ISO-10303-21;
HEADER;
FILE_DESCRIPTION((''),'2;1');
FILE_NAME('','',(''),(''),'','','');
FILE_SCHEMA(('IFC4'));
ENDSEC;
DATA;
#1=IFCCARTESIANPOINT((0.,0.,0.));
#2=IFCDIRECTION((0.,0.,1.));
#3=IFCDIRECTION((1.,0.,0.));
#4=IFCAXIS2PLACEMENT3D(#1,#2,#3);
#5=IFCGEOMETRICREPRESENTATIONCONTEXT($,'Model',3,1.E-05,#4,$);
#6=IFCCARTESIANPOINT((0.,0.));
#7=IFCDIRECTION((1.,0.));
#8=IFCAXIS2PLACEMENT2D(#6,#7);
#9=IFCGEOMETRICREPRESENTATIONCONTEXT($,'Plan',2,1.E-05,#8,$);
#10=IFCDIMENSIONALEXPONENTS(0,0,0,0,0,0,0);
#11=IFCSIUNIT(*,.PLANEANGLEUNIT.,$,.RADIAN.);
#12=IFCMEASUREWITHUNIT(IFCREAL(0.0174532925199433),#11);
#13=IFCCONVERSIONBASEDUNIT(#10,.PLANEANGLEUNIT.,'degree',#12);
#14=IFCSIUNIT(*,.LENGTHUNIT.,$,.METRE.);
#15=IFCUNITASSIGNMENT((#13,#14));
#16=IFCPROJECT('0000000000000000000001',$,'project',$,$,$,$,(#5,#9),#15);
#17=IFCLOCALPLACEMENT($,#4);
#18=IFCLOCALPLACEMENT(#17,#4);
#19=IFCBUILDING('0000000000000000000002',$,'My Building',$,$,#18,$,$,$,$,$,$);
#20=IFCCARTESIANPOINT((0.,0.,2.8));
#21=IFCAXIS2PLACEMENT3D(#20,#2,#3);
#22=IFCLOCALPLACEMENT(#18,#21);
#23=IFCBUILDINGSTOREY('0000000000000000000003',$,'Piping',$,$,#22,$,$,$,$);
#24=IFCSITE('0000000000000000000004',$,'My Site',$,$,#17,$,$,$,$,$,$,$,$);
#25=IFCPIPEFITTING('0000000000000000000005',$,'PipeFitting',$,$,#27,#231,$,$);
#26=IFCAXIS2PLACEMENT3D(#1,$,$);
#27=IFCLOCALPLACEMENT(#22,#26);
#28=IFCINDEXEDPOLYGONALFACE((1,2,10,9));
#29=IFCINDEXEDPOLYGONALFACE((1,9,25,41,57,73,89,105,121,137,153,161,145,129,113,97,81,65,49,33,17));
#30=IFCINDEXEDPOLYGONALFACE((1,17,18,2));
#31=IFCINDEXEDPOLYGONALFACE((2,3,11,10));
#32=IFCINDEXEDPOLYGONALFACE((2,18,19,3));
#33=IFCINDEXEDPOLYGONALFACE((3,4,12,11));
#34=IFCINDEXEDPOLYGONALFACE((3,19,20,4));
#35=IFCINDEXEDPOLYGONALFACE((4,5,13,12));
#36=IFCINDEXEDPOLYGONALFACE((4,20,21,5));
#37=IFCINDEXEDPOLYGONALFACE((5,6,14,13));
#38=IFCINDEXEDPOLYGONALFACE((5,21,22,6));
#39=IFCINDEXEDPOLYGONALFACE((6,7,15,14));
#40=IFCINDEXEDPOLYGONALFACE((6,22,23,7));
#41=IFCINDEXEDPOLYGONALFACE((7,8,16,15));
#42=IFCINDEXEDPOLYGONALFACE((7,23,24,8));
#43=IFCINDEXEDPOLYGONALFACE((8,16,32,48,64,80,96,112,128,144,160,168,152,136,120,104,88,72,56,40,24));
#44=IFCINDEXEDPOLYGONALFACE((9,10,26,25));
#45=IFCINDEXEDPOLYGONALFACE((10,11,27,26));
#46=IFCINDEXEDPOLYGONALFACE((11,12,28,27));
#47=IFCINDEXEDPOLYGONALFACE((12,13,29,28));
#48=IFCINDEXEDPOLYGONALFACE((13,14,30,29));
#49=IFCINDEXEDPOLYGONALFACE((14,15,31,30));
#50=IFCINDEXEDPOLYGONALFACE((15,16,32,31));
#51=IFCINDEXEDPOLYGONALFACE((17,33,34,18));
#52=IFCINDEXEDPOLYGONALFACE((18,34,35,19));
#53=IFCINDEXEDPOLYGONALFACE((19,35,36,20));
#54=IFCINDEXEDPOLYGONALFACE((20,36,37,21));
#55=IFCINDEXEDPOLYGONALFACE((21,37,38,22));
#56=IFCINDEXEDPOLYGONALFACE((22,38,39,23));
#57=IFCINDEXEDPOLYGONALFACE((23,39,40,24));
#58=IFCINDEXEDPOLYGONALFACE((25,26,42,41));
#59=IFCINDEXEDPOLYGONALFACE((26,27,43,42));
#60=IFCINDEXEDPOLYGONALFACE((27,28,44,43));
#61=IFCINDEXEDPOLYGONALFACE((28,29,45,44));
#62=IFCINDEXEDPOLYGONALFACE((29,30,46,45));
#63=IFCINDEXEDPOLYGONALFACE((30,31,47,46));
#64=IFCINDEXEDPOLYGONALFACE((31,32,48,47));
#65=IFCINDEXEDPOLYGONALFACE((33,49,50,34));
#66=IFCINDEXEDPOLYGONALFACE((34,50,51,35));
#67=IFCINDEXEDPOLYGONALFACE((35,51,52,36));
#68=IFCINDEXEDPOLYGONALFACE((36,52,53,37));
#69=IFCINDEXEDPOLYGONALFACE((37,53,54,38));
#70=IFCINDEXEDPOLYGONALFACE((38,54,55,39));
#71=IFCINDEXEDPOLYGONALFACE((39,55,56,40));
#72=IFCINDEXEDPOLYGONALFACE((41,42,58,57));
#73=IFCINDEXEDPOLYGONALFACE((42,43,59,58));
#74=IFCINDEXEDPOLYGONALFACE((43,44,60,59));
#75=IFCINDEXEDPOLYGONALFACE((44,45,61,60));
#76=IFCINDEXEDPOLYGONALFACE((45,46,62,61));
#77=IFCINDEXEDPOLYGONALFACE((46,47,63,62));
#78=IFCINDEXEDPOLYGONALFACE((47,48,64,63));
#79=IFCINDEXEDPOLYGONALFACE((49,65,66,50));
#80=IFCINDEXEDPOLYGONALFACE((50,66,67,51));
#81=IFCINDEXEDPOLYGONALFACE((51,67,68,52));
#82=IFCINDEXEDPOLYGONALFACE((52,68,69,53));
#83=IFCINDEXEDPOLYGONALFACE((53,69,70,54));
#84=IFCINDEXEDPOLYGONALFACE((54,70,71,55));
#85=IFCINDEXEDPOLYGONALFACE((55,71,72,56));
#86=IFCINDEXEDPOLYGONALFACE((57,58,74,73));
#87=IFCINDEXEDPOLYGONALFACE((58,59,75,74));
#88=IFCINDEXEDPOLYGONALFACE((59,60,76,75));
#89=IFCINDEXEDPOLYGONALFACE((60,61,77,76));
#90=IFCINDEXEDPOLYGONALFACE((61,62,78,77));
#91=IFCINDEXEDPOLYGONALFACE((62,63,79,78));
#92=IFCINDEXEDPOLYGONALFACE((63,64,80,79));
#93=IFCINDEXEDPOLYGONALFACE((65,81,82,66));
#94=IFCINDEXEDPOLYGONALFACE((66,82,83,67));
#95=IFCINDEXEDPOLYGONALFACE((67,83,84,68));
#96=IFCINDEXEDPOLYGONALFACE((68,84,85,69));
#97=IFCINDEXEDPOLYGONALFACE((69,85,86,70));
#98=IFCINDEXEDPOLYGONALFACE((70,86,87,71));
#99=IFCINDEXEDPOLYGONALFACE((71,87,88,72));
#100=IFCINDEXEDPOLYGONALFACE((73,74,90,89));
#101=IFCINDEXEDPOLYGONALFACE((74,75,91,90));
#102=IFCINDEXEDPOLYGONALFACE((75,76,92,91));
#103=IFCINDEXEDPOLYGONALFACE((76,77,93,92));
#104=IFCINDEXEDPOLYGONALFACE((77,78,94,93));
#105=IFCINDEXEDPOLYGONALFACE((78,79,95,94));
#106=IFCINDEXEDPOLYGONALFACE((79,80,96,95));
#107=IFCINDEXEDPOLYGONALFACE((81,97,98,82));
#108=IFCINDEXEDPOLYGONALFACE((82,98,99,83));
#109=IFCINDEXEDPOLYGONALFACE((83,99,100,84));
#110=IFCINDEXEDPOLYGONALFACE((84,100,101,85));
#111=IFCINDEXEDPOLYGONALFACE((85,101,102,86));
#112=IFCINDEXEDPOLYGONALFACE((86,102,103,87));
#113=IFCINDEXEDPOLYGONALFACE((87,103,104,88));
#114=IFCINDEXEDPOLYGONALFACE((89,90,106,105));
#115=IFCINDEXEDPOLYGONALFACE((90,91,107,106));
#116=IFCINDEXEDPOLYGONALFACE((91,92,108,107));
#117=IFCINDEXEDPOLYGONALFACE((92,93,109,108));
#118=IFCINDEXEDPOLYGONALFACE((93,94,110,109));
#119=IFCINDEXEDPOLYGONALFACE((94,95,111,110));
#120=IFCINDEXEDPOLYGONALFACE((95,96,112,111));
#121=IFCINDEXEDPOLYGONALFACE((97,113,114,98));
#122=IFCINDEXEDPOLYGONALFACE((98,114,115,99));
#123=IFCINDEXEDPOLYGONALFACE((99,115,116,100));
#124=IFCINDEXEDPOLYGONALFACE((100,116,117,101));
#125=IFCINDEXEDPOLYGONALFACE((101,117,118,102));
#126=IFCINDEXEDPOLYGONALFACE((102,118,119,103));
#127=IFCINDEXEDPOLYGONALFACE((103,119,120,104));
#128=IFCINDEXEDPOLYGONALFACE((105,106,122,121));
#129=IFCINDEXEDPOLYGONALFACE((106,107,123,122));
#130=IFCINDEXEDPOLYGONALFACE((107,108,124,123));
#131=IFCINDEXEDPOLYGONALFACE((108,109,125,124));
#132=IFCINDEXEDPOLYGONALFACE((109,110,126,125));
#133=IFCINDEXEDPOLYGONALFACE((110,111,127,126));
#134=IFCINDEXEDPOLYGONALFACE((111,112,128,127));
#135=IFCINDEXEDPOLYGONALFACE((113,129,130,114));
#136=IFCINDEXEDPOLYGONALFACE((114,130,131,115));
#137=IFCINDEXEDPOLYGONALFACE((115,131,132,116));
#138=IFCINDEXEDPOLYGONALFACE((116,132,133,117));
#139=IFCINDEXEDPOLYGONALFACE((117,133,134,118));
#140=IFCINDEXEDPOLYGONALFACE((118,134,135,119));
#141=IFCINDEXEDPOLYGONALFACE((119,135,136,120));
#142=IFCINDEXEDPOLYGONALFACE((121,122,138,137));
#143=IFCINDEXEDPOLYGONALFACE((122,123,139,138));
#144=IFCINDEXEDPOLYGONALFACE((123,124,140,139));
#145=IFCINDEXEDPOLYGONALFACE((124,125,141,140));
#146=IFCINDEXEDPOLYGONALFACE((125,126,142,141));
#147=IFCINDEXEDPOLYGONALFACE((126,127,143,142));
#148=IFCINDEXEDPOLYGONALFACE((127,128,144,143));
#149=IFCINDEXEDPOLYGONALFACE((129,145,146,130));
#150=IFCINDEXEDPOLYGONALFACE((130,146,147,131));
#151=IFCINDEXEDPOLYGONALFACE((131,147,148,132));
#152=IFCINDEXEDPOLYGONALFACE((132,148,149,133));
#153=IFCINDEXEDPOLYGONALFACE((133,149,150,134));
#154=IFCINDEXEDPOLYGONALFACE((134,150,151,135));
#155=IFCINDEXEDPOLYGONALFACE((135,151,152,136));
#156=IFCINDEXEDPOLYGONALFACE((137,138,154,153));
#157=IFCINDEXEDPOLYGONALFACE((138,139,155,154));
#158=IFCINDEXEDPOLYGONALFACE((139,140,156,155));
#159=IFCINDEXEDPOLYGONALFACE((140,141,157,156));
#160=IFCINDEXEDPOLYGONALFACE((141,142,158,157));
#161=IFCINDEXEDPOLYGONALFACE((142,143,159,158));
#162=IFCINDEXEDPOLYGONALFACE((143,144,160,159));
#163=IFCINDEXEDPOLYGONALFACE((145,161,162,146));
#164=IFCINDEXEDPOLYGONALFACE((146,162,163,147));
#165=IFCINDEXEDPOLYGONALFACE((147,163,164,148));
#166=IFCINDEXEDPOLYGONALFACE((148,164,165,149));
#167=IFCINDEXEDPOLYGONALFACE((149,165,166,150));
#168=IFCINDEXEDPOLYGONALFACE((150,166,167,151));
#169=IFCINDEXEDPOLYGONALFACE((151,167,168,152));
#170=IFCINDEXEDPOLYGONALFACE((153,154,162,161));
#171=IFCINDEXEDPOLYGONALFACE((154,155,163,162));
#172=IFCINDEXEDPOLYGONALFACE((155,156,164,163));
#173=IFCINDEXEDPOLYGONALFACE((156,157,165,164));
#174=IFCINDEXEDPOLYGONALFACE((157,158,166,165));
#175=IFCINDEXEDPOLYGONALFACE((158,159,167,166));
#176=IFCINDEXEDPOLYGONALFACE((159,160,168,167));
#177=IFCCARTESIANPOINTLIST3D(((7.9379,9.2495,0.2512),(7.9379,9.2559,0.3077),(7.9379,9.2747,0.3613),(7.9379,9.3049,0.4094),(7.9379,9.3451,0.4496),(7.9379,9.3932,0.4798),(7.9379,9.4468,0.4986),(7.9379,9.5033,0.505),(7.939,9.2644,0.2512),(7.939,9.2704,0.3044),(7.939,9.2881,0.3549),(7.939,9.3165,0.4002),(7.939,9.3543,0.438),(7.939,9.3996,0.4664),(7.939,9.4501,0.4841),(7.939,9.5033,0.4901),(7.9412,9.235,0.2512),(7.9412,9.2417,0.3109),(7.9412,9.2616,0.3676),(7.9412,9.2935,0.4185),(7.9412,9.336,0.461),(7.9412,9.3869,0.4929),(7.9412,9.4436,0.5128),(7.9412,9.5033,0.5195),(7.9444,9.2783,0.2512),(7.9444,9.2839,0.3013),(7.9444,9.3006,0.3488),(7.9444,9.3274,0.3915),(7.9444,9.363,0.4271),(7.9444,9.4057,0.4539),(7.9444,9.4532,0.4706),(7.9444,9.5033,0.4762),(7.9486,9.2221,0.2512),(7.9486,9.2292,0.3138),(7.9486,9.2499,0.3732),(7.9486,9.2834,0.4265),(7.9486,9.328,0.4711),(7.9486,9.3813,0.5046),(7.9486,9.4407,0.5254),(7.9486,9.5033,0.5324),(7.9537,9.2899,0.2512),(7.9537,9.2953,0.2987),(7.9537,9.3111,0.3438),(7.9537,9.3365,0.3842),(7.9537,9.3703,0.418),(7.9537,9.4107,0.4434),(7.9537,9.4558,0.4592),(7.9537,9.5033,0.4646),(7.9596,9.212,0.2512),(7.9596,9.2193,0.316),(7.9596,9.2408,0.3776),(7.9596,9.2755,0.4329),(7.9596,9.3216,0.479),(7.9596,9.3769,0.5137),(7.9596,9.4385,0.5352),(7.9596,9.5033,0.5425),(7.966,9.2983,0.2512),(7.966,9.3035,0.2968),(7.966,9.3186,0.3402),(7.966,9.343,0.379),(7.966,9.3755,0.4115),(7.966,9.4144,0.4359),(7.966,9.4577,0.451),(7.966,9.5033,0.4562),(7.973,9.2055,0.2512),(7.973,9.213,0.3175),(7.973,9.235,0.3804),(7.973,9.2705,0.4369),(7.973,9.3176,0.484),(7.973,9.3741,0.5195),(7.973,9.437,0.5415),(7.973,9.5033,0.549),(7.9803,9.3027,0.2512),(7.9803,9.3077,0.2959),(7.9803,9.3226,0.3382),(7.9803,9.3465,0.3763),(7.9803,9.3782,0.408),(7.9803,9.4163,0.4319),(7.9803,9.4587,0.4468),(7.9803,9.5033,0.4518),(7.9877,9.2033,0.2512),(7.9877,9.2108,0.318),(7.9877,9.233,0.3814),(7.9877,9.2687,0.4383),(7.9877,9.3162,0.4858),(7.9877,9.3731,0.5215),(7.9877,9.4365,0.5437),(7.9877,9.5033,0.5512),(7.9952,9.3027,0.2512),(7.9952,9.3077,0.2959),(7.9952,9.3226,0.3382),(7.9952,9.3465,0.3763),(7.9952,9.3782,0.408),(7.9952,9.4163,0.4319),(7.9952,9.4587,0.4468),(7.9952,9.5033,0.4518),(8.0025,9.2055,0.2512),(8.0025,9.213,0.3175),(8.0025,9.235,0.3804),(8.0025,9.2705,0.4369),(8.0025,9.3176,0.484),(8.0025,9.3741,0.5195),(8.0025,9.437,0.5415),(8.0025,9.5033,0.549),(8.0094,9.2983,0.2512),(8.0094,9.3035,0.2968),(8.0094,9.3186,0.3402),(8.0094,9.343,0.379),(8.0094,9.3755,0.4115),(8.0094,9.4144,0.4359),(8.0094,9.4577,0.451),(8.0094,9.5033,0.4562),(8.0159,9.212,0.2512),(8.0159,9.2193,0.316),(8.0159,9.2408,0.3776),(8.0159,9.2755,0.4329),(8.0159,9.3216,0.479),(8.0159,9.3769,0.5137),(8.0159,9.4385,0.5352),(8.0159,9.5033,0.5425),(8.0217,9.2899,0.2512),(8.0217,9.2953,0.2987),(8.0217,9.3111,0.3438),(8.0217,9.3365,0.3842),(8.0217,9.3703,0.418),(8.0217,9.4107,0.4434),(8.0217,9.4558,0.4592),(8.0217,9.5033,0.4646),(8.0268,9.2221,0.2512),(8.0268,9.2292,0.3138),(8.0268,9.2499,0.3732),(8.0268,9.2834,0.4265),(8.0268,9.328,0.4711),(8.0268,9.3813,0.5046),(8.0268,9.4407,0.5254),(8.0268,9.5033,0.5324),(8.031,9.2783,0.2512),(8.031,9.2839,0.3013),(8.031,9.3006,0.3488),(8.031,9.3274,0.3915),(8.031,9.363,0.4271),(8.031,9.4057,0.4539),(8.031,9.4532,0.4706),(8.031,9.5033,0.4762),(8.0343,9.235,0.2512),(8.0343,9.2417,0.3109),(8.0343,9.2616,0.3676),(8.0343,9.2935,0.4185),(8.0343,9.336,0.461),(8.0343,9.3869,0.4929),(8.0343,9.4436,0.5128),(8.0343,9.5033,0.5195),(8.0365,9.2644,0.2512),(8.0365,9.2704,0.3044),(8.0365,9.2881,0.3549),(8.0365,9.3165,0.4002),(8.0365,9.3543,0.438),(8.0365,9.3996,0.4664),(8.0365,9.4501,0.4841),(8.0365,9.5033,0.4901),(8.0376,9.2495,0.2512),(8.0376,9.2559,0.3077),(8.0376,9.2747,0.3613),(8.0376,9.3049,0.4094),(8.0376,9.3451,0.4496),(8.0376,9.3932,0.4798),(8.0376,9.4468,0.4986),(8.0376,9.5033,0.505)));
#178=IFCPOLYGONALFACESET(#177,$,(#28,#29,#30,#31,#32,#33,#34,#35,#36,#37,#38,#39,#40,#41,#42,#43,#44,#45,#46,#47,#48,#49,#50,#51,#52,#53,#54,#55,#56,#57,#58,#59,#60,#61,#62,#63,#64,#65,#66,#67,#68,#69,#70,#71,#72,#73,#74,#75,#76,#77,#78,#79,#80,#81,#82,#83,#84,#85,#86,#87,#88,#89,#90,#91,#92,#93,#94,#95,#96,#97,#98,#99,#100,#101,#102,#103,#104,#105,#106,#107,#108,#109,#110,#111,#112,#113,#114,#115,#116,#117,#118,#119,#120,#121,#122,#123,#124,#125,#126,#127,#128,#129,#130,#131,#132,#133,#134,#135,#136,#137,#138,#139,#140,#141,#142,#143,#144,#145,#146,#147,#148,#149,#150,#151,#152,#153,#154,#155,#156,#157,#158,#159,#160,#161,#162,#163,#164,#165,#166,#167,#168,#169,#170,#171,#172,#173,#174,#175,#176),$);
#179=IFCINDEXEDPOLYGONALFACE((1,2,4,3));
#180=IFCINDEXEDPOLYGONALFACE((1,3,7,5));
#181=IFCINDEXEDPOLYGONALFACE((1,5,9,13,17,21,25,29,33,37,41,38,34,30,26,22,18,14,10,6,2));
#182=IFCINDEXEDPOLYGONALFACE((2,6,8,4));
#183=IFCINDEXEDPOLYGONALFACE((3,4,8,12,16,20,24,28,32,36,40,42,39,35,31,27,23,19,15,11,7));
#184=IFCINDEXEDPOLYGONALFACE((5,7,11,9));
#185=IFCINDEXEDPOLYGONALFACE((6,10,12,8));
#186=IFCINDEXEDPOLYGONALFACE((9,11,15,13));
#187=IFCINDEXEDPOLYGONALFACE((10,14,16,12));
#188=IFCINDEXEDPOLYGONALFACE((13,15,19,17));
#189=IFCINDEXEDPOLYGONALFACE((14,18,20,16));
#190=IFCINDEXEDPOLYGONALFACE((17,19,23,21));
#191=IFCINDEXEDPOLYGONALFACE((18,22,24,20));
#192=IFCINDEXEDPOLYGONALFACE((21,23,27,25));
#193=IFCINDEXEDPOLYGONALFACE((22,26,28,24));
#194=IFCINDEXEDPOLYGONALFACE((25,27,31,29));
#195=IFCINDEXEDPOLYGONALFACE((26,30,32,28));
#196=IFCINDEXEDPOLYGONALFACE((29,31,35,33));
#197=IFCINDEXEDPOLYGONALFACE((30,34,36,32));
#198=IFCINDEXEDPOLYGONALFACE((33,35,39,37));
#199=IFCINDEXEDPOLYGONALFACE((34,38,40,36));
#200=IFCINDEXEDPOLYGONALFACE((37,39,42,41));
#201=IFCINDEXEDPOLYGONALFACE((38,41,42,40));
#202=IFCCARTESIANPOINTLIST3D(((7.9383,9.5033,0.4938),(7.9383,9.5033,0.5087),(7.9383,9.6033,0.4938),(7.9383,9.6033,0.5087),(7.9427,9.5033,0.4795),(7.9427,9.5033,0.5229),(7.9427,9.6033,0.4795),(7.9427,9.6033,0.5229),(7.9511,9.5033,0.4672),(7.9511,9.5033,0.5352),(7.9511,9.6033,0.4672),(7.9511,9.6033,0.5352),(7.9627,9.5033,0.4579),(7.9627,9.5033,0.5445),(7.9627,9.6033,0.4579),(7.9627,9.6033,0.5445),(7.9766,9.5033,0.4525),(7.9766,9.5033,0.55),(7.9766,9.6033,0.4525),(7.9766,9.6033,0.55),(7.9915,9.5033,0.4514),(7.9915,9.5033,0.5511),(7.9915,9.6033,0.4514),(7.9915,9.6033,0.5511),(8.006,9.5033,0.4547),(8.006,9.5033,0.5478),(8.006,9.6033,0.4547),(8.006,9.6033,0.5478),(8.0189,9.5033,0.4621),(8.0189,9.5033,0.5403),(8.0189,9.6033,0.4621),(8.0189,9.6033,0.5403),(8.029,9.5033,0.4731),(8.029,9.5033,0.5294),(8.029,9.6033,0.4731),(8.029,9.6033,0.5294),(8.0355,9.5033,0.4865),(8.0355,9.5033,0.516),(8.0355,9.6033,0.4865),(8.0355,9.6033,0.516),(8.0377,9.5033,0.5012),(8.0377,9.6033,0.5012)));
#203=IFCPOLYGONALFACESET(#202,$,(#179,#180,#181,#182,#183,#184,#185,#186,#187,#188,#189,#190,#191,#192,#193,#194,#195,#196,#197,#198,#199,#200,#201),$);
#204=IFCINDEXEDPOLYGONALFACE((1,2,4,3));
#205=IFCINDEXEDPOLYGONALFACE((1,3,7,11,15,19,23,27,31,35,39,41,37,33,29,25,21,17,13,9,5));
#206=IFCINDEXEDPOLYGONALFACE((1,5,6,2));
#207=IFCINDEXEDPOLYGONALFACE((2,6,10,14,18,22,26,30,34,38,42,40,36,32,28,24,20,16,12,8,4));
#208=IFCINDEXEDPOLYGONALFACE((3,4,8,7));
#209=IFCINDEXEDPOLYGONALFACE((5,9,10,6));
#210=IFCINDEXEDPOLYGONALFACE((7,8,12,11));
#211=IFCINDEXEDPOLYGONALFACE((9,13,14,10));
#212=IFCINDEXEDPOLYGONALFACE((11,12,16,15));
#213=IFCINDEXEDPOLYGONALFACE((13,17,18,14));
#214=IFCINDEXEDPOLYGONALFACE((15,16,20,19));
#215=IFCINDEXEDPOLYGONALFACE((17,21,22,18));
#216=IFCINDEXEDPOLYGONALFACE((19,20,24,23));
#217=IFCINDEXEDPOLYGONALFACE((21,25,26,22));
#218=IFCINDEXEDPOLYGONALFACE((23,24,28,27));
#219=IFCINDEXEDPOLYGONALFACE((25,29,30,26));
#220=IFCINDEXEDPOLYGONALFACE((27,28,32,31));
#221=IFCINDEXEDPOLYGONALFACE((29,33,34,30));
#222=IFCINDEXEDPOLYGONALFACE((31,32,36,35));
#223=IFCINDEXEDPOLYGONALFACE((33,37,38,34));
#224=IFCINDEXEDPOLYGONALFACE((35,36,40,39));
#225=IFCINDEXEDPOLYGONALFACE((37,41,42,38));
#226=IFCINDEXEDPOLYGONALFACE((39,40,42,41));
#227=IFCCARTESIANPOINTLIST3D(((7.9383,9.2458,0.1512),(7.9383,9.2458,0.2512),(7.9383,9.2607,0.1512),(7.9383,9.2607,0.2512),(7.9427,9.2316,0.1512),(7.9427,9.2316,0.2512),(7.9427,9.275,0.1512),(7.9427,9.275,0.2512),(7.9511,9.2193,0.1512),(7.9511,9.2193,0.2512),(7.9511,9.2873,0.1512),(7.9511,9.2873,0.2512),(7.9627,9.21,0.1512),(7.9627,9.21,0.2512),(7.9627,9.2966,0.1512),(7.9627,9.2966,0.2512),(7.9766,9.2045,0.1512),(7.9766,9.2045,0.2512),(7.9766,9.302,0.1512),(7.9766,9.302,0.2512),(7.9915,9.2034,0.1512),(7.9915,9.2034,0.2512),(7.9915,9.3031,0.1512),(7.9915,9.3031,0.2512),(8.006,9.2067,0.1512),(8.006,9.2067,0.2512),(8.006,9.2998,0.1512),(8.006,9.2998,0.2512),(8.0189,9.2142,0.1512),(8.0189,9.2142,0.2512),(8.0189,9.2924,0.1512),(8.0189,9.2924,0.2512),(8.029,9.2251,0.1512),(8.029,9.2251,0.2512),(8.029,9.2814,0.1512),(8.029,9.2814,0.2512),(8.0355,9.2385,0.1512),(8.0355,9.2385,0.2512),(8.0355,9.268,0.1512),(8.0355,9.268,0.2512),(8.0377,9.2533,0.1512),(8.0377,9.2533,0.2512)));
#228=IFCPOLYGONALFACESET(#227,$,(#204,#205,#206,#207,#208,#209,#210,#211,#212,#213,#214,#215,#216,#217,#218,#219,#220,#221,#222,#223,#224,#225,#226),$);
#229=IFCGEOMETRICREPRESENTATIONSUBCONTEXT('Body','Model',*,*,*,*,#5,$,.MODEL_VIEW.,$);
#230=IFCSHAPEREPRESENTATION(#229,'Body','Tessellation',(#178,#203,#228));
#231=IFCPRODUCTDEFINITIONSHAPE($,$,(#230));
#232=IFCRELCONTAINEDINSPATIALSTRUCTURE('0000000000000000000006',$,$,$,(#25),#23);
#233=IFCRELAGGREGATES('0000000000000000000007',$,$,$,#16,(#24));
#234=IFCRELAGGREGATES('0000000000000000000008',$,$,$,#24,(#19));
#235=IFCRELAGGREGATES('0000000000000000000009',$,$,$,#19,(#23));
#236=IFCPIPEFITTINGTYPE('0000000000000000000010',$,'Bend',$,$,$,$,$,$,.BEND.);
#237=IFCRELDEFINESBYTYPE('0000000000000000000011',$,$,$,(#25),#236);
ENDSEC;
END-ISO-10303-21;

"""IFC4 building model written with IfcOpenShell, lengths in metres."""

from ifc_helpers import new_model, entity, si_unit, converted_unit, frame, origin_with_axes, origin_2d_with_axis, place, context, subcontext, project, spatial, circle, extrude, source, transform, mapped, type_object, type_shapes, element, save


model = new_model("IFC4")

# Units and contexts
model_context = context("Model", 3, precision=1e-05, world=origin_with_axes())
plan_context = context("Plan", 2, precision=1e-05, world=origin_2d_with_axis())
body_context = subcontext(model_context, "Body", "Model", "MODEL_VIEW")
ifc_project = project(units=[converted_unit("PLANEANGLEUNIT", "degree", entity("IfcReal", 0.0174532925199433), si_unit("PLANEANGLEUNIT", "RADIAN"), dimensions=[0, 0, 0, 0, 0, 0, 0]), si_unit("LENGTHUNIT", "METRE")], contexts=[model_context, plan_context])

# Site, building, storey
site_placement = place(None, origin_with_axes())
site = spatial("IfcSite", under=ifc_project, at=site_placement, Name="My Site")
building_placement = place(site_placement, origin_with_axes())
building = spatial("IfcBuilding", under=site, at=building_placement, Name="My Building")
storey_placement = place(building_placement, frame((0.0, 0.0, 2.8), z_axis=(0.0, 0.0, 1.0), x_axis=(1.0, 0.0, 0.0)))
storey = spatial("IfcBuildingStorey", under=building, at=storey_placement, Name="Piping")

# Pipe fitting
pipe_fitting_type_1 = type_object("IfcPipeFittingType", Name="Bend", PredefinedType="BEND")
shared_shape_1 = source(origin_with_axes(), body_context, "Body", "SolidModel", [
    entity("IfcSweptDiskSolid", entity("IfcIndexedPolyCurve", entity("IfcCartesianPointList3D", [[0.0, 0.0, 0.1], [0.0, -0.0732, 0.2768], [0.0, -0.25, 0.35]]), [entity("IfcArcIndex", [1, 2, 3])]), 0.05),
    extrude(circle(Radius=0.05), origin_with_axes(), (0.0, 0.0, 1.0), 0.1),
    extrude(circle(Radius=0.05), frame((0.0, -0.25, 0.35), z_axis=(0.0, -1.0, 0.0), x_axis=(1.0, 0.0, 0.0)), (0.0, 0.0, 1.0), 0.1),
])
type_shapes(pipe_fitting_type_1, [shared_shape_1])
for number, where, z_axis, x_axis, name in (
    (1, (7.9877, 9.6033, 0.5012), (0.0, -1.0, 0.0), (1.0, 0.0, 0.0), "PipeFitting"),
):
    element("IfcPipeFitting", number, at=place(storey_placement, frame(where, z_axis=z_axis, x_axis=x_axis)), inside=storey, type_object=pipe_fitting_type_1, Name=name, context=body_context, shape_type="MappedRepresentation", body=[
        mapped(shared_shape_1, transform((0.0, 0.0, 0.0), x_axis=(1.0, 0.0, 0.0), y_axis=(0.0, 1.0, 0.0), z_axis=(0.0, 0.0, 1.0), scale=1.0)),
    ])

save(model, "model.ifc")
